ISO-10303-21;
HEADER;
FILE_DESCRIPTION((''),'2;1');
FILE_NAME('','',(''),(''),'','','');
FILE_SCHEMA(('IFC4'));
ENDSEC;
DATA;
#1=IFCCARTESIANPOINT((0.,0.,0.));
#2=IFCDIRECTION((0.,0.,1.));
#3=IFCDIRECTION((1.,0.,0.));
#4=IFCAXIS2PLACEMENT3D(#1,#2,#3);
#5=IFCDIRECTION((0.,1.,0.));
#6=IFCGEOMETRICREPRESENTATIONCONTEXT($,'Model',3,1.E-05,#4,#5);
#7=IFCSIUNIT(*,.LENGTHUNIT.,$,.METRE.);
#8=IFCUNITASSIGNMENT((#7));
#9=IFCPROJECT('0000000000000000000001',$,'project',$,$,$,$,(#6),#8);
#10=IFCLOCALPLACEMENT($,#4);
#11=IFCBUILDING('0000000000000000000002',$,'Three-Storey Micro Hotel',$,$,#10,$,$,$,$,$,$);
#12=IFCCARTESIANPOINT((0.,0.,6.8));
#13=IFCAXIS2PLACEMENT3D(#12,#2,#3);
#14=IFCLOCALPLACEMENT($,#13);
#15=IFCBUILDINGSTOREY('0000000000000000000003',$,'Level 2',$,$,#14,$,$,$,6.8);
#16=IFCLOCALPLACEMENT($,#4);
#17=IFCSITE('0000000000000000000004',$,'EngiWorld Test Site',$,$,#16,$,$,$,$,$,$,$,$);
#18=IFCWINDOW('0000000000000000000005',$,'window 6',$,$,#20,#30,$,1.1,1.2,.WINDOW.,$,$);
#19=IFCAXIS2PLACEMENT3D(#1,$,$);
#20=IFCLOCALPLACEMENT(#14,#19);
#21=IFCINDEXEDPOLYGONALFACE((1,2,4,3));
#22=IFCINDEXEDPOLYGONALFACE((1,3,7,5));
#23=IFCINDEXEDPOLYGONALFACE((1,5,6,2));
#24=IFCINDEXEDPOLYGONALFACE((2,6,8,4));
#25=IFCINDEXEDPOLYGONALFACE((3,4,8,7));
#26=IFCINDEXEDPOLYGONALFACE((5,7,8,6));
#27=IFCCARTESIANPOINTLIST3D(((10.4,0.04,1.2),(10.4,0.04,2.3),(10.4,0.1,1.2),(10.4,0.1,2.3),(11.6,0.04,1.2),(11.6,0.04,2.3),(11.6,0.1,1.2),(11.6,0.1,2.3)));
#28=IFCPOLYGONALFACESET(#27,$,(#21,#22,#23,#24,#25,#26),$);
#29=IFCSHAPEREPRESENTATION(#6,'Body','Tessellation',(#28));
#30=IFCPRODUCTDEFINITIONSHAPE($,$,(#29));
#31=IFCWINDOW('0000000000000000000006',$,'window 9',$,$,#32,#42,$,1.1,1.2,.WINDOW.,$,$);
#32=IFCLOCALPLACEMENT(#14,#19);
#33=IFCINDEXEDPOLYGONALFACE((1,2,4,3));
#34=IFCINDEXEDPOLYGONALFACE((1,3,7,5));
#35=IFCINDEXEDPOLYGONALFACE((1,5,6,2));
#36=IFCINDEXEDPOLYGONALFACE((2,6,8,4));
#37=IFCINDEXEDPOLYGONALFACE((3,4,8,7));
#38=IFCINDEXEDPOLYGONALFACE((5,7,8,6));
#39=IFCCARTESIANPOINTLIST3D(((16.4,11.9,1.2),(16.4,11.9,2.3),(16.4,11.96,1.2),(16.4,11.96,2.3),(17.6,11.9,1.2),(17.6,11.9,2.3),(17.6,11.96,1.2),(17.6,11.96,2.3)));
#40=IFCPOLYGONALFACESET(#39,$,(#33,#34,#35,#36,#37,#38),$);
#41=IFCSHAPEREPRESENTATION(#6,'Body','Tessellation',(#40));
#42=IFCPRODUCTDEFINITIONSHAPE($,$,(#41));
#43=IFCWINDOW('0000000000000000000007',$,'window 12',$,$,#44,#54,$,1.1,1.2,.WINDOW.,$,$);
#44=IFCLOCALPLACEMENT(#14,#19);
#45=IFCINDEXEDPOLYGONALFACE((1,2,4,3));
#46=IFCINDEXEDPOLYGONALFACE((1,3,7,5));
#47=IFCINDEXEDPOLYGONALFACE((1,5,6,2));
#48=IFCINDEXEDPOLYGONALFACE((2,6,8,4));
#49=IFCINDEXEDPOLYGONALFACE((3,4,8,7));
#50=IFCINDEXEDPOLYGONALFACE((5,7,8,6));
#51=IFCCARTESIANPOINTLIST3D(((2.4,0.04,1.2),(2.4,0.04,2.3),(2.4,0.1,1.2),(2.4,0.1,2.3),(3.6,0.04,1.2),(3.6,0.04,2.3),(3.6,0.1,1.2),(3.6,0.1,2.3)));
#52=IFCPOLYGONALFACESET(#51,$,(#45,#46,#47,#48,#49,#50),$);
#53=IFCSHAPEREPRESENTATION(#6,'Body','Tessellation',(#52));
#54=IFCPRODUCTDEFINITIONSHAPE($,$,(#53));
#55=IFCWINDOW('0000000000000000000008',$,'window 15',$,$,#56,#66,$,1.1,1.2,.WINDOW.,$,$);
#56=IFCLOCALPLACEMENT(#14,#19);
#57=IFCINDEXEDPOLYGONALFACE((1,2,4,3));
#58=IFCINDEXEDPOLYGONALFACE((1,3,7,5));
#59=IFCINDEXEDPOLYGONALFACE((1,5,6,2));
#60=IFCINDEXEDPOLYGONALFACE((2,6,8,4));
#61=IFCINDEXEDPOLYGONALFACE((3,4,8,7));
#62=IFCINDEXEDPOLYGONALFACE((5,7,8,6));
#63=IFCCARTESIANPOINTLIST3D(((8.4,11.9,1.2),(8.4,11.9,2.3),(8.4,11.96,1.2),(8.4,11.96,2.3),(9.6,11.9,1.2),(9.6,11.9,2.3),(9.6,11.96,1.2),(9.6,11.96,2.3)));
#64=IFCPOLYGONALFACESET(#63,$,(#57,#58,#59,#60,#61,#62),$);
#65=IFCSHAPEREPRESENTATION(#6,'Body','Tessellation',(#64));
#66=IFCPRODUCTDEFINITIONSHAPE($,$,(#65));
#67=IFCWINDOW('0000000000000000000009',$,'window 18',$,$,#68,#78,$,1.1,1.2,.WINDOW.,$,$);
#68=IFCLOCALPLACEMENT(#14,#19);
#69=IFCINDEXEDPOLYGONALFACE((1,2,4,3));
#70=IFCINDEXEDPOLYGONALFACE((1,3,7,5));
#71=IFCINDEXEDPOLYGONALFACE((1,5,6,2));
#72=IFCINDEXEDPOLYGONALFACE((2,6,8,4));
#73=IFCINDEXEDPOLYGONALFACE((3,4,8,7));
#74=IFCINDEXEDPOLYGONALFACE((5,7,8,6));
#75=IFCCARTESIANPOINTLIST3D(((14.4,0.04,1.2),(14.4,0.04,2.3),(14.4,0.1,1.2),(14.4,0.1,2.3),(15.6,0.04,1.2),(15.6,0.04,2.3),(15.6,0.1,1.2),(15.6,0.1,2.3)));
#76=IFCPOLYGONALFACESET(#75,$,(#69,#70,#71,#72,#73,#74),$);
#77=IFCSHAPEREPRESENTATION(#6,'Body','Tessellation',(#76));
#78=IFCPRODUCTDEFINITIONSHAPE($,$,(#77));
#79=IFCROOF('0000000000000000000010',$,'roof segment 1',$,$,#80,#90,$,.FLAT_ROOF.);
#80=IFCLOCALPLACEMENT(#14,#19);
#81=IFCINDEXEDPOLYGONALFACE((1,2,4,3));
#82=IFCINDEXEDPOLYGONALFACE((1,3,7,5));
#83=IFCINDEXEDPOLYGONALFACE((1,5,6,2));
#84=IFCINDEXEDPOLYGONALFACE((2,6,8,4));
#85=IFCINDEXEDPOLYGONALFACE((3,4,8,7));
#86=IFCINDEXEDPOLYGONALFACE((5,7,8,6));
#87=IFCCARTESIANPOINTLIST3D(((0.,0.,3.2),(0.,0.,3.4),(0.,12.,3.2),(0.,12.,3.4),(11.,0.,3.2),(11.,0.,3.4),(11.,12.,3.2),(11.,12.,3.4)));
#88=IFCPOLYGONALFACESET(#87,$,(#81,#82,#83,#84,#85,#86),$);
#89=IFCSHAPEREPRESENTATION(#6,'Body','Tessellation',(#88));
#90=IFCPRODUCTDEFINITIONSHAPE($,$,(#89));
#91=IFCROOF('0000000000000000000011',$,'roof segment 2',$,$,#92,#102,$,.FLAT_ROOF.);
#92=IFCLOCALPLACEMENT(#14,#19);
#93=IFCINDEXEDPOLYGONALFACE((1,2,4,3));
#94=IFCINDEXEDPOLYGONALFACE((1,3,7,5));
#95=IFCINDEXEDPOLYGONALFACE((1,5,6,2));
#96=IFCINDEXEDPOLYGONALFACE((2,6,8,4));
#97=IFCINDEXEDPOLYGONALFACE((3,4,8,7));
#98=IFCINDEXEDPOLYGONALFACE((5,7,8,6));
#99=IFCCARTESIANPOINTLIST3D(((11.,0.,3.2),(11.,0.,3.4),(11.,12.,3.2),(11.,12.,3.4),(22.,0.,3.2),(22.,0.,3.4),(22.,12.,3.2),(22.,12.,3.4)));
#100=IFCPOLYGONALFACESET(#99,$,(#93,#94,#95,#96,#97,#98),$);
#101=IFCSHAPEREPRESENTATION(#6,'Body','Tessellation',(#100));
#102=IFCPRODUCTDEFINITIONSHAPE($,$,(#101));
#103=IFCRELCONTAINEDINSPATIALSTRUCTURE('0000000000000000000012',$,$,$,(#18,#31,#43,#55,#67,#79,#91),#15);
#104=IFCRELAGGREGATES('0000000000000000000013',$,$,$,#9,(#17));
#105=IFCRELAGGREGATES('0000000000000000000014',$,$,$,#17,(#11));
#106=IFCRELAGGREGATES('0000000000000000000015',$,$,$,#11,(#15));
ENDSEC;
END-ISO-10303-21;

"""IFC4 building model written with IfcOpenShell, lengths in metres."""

from ifc_helpers import new_model, si_unit, direction, frame, origin_with_axes, origin_2d_with_axis, place, context, project, spatial, rectangle, extrude, element, save


model = new_model("IFC4")

# Units and contexts
model_context = context("Model", 3, precision=1e-05, world=origin_with_axes(), true_north=direction((0.0, 1.0, 0.0)))
ifc_project = project(units=[si_unit("LENGTHUNIT", "METRE")], contexts=[model_context])

# Site, building, storey
site_placement = place(None, origin_with_axes())
site = spatial("IfcSite", under=ifc_project, at=site_placement, Name="EngiWorld Test Site")
building_placement = place(None, origin_with_axes())
building = spatial("IfcBuilding", under=site, at=building_placement, Name="Three-Storey Micro Hotel")
storey_placement = place(None, frame((0.0, 0.0, 6.8), z_axis=(0.0, 0.0, 1.0), x_axis=(1.0, 0.0, 0.0)))
storey = spatial("IfcBuildingStorey", under=building, at=storey_placement, Name="Level 2", Elevation=6.8)

# Windows
for number, where, z_axis, x_axis, name in (
    (1, (11.0, 0.07, 8.0), (0.0, 0.0, 1.0), (1.0, 0.0, 0.0), "window 6"),
    (2, (17.0, 11.93, 8.0), (0.0, 0.0, 1.0), (1.0, 0.0, 0.0), "window 9"),
    (3, (3.0, 0.07, 8.0), (0.0, 0.0, 1.0), (1.0, 0.0, 0.0), "window 12"),
    (4, (9.0, 11.93, 8.0), (0.0, 0.0, 1.0), (1.0, 0.0, 0.0), "window 15"),
    (5, (15.0, 0.07, 8.0), (0.0, 0.0, 1.0), (1.0, 0.0, 0.0), "window 18"),
):
    element("IfcWindow", number, at=place(None, frame(where, z_axis=z_axis, x_axis=x_axis)), inside=storey, Name=name, OverallHeight=1.1, OverallWidth=1.2, PredefinedType="WINDOW", context=model_context, shape_type="SweptSolid", body=[
        extrude(rectangle(XDim=1.2, YDim=0.06, at=origin_2d_with_axis()), origin_with_axes(), (0.0, 0.0, 1.0), 1.1),
    ])

# Roofs
for number, where, z_axis, x_axis, name in (
    (6, (5.5, 6.0, 10.0), (0.0, 0.0, 1.0), (1.0, 0.0, 0.0), "roof segment 1"),
    (7, (16.5, 6.0, 10.0), (0.0, 0.0, 1.0), (1.0, 0.0, 0.0), "roof segment 2"),
):
    element("IfcRoof", number, at=place(None, frame(where, z_axis=z_axis, x_axis=x_axis)), inside=storey, Name=name, PredefinedType="FLAT_ROOF", context=model_context, shape_type="SweptSolid", body=[
        extrude(rectangle(XDim=11.0, YDim=12.0, at=origin_2d_with_axis()), origin_with_axes(), (0.0, 0.0, 1.0), 0.2),
    ])

save(model, "model.ifc")
